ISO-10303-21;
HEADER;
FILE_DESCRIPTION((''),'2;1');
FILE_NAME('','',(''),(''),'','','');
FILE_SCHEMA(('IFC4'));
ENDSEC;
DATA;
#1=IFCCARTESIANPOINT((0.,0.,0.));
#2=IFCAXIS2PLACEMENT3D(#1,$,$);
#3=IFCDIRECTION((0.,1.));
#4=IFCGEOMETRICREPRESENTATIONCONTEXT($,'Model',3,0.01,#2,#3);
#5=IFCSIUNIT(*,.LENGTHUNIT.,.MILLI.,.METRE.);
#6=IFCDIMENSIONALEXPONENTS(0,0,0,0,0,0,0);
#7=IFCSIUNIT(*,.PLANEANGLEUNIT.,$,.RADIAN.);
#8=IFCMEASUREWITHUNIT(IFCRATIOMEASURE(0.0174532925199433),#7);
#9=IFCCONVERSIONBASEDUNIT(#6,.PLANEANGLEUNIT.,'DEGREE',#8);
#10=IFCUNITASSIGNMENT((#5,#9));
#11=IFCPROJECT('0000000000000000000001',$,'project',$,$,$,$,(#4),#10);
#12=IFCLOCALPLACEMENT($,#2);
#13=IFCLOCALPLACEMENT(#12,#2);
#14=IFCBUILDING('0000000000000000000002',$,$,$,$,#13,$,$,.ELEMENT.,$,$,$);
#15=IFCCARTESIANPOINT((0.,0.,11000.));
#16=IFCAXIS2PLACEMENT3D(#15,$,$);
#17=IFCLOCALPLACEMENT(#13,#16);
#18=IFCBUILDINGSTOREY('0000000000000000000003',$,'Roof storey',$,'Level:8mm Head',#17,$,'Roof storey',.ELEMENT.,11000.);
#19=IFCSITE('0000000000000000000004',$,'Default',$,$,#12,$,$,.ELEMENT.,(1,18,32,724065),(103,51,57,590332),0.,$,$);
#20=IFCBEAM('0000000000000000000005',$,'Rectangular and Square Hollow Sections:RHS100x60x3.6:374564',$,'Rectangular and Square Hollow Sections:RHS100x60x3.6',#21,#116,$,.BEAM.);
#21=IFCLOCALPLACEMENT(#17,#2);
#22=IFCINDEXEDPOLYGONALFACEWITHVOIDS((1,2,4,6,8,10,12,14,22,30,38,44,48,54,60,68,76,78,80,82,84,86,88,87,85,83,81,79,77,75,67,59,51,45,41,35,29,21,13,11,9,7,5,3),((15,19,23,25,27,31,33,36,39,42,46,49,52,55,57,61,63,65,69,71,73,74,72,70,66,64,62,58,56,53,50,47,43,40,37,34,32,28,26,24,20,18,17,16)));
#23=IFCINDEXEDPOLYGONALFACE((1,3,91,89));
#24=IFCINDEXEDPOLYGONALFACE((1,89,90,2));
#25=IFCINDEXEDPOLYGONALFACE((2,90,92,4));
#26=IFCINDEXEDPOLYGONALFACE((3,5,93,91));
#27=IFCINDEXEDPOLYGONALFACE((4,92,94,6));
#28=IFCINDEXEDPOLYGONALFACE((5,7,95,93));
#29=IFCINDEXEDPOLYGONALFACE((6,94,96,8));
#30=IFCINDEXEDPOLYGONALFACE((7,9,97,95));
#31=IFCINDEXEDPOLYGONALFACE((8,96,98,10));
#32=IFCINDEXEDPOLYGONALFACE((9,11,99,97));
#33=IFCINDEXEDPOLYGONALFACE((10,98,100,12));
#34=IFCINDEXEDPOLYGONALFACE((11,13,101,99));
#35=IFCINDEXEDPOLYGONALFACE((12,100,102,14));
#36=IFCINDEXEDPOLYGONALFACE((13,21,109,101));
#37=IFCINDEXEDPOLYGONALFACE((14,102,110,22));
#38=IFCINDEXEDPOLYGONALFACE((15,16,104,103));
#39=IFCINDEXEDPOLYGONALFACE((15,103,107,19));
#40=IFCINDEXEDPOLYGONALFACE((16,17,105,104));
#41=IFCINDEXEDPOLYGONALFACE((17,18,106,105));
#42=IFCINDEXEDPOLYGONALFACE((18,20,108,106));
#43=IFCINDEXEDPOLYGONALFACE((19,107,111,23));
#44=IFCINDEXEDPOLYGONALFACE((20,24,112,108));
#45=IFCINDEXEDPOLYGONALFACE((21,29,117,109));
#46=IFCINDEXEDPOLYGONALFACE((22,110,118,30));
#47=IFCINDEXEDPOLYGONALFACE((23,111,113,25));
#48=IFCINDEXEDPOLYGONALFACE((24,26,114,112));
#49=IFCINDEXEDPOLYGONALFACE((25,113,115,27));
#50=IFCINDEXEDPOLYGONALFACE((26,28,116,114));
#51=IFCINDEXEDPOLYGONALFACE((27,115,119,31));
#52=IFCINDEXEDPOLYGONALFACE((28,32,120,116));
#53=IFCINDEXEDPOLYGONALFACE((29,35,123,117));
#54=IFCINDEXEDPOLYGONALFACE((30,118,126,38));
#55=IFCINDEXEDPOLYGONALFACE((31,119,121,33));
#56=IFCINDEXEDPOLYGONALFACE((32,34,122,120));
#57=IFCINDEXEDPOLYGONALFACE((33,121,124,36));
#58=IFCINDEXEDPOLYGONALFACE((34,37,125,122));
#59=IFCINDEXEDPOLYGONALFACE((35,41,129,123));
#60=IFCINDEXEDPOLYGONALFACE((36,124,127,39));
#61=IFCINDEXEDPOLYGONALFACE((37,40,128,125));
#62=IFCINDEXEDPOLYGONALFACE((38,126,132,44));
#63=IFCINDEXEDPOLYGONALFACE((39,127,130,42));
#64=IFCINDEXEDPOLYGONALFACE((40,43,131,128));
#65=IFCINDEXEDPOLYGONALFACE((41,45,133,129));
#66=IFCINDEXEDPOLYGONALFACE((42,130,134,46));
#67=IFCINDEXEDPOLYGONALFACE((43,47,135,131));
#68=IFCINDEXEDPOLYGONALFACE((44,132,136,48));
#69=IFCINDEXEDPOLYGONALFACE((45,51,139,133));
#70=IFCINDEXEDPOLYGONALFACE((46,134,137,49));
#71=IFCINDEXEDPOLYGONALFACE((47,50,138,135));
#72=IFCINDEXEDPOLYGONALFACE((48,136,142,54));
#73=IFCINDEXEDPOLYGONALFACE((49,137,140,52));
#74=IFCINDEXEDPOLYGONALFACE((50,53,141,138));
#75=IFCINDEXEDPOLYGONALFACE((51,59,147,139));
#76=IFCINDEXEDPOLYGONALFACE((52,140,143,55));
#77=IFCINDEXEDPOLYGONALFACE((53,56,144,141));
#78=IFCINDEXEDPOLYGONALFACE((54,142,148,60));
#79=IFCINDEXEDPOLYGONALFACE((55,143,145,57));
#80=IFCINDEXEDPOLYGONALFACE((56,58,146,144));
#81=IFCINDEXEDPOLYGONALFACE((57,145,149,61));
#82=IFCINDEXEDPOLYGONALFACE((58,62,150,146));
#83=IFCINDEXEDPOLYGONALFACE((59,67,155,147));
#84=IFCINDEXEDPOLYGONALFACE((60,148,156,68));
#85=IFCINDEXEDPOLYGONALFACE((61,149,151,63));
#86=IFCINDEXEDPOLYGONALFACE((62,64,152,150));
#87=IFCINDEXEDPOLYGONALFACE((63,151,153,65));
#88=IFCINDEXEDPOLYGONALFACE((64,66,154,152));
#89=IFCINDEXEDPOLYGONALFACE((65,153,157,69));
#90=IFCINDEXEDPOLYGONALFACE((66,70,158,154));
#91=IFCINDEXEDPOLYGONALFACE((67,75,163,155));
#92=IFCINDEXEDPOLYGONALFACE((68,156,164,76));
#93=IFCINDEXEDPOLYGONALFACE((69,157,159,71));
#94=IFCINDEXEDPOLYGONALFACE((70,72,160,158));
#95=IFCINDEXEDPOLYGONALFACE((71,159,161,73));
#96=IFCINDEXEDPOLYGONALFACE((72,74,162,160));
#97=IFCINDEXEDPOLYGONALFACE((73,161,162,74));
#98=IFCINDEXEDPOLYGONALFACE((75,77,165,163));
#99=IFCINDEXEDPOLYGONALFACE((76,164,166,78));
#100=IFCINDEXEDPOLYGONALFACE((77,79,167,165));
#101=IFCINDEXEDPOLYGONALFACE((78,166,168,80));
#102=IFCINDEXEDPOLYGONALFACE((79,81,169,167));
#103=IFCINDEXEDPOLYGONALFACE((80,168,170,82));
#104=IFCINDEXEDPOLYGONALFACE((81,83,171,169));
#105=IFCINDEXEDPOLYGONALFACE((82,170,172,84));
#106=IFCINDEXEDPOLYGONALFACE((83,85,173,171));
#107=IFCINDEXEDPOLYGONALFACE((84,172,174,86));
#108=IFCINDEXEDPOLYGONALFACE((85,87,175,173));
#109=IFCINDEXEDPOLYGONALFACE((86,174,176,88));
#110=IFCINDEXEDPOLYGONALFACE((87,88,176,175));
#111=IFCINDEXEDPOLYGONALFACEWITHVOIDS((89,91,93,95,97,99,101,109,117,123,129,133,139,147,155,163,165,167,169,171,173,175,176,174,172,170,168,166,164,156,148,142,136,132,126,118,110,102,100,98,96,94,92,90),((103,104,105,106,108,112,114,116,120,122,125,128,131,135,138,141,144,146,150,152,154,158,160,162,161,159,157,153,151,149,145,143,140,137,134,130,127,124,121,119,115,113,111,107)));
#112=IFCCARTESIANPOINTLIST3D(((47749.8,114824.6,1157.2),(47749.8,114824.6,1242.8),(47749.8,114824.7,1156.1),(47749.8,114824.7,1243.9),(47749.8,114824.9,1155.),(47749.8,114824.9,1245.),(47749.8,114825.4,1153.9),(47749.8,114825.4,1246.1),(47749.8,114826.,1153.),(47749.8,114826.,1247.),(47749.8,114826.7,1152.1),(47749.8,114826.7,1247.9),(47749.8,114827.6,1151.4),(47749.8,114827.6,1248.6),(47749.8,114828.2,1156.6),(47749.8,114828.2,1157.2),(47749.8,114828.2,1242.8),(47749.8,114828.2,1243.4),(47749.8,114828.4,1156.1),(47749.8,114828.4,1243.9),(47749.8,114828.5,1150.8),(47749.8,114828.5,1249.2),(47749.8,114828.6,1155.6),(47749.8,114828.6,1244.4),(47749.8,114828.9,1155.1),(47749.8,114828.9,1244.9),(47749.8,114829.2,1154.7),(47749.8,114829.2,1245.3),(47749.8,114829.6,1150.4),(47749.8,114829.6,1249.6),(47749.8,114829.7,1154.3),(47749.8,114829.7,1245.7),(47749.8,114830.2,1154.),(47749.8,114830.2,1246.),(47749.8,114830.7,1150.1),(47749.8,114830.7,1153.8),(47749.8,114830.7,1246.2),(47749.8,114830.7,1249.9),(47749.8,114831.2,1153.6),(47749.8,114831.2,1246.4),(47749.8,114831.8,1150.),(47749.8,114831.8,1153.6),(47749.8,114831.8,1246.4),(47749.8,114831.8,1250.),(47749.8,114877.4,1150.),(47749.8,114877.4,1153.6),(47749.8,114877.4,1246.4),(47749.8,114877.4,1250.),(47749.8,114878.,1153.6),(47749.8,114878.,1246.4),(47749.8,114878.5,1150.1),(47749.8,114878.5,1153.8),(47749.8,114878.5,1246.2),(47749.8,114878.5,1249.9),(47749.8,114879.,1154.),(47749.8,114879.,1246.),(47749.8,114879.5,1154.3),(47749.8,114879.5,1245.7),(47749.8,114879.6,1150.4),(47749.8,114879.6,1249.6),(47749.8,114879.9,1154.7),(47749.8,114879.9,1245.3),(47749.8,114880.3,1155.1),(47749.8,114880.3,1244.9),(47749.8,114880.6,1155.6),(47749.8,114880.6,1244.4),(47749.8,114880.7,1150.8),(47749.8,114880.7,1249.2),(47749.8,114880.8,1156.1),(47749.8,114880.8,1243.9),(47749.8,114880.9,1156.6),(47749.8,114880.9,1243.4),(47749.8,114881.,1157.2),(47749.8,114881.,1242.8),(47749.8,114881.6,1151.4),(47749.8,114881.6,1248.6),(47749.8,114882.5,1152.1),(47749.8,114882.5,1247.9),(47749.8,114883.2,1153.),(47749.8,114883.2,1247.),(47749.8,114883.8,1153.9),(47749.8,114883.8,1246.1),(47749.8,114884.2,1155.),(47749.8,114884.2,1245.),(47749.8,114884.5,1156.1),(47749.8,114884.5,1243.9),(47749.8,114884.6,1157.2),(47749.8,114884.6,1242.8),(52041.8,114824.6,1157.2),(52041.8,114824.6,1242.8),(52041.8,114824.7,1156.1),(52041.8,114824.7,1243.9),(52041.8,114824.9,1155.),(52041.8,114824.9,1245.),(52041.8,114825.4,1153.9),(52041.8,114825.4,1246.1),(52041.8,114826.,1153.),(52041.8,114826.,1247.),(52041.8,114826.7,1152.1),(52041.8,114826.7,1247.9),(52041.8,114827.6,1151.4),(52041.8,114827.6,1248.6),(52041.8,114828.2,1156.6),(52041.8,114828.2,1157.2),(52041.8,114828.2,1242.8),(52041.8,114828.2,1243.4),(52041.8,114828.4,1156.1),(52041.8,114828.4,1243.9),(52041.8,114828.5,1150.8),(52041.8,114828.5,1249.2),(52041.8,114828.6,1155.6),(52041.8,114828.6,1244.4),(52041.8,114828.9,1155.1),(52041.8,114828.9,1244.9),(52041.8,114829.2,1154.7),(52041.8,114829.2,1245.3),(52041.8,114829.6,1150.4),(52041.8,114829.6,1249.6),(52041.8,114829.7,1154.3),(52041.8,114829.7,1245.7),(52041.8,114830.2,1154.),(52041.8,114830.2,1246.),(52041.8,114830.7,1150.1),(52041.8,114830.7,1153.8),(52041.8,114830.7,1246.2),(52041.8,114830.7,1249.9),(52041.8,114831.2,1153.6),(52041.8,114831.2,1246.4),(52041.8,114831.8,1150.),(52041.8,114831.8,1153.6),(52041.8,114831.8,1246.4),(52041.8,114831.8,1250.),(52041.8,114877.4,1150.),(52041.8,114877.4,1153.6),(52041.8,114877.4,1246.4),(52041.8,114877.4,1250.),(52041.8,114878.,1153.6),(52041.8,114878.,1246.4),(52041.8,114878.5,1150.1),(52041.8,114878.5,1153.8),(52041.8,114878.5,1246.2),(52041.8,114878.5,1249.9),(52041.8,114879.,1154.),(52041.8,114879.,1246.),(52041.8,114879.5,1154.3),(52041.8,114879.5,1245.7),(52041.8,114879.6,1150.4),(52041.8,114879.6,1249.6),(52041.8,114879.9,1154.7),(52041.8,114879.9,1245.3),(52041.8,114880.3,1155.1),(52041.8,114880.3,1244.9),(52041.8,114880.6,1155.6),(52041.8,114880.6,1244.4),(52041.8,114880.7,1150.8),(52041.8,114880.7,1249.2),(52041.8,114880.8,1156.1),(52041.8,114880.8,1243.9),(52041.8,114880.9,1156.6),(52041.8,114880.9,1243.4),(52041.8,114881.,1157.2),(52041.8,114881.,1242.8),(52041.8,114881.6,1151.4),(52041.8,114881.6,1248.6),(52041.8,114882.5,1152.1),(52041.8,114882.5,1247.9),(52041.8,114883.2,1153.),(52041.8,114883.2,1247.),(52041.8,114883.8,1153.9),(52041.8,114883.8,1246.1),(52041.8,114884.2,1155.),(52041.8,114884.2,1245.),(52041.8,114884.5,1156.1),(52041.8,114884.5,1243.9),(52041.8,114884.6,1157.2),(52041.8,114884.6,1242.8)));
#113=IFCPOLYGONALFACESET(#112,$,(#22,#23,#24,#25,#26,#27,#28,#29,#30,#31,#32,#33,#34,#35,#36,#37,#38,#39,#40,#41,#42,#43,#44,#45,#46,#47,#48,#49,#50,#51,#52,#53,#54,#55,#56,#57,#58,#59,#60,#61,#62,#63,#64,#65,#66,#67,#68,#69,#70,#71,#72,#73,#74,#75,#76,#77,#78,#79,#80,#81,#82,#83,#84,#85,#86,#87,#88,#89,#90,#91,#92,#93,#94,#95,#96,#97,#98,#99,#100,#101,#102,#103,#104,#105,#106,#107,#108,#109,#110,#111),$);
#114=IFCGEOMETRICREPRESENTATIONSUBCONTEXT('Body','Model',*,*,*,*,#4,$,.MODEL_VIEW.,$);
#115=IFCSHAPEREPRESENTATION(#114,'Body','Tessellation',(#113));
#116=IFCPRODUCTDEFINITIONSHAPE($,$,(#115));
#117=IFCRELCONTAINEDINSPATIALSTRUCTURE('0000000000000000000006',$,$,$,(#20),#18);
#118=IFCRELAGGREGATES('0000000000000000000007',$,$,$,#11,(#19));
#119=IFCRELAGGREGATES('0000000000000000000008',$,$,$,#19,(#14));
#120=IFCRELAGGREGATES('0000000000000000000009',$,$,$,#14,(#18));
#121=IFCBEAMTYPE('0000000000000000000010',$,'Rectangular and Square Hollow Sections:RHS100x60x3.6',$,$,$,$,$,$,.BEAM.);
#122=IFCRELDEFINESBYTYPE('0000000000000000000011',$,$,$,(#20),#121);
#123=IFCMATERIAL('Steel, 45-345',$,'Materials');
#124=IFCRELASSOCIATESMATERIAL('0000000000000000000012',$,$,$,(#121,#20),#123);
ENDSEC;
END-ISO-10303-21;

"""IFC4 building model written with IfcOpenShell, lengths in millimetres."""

from ifc_helpers import new_model, entity, si_unit, converted_unit, direction, frame, origin, place, context, subcontext, project, spatial, indexed_curve, outline, extrude, source, transform, mapped, material, type_object, type_shapes, element, save


model = new_model("IFC4")

# Units and contexts
model_context = context("Model", 3, precision=0.01, world=origin(), true_north=direction((0.0, 1.0)))
body_context = subcontext(model_context, "Body", "Model", "MODEL_VIEW")
ifc_project = project(units=[si_unit("LENGTHUNIT", "METRE", prefix="MILLI"), converted_unit("PLANEANGLEUNIT", "DEGREE", entity("IfcRatioMeasure", 0.0174532925199433), si_unit("PLANEANGLEUNIT", "RADIAN"), dimensions=[0, 0, 0, 0, 0, 0, 0])], contexts=[model_context])

# Site, building, storey
site_placement = place(None, origin())
site = spatial("IfcSite", under=ifc_project, at=site_placement, Name="Default", CompositionType="ELEMENT", RefLatitude=(1, 18, 32, 724065), RefLongitude=(103, 51, 57, 590332), RefElevation=0.0)
building_placement = place(site_placement, origin())
building = spatial("IfcBuilding", under=site, at=building_placement, CompositionType="ELEMENT")
storey_placement = place(building_placement, frame((0.0, 0.0, 11000.0)))
storey = spatial("IfcBuildingStorey", under=building, at=storey_placement, Name="Roof storey", ObjectType="Level:8mm Head", LongName="Roof storey", CompositionType="ELEMENT", Elevation=11000.0)

# Shared definitions
ifc_material = material(Name="Steel, 45-345", Category="Materials")

# Beam
beam_type_1 = type_object("IfcBeamType", Name="Rectangular and Square Hollow Sections:RHS100x60x3.6", PredefinedType="BEAM", material=ifc_material)
shared_shape_1 = source(origin(), body_context, "Body", "SweptSolid", [
    extrude(outline(indexed_curve([(-30.0, -42.8), (-29.9, -43.9), (-29.6, -45.0), (-29.2, -46.1), (-28.6, -47.0), (-27.9, -47.9), (-27.0, -48.6), (-26.1, -49.2), (-25.0, -49.6), (-23.9, -49.9), (-22.8, -50.0), (22.8, -50.0), (23.9, -49.9), (25.0, -49.6), (26.1, -49.2), (27.0, -48.6), (27.9, -47.9), (28.6, -47.0), (29.2, -46.1), (29.6, -45.0), (29.9, -43.9), (30.0, -42.8), (30.0, 42.8), (29.9, 43.9), (29.6, 45.0), (29.2, 46.1), (28.6, 47.0), (27.9, 47.9), (27.0, 48.6), (26.1, 49.2), (25.0, 49.6), (23.9, 49.9), (22.8, 50.0), (-22.8, 50.0), (-23.9, 49.9), (-25.0, 49.6), (-26.1, 49.2), (-27.0, 48.6), (-27.9, 47.9), (-28.6, 47.0), (-29.2, 46.1), (-29.6, 45.0), (-29.9, 43.9), (-30.0, 42.8), (-30.0, -42.8)], self_intersect=False), holes=[indexed_curve([(22.8, -46.4), (-22.8, -46.4), (-23.4, -46.4), (-23.9, -46.2), (-24.4, -46.0), (-24.9, -45.7), (-25.3, -45.3), (-25.7, -44.9), (-26.0, -44.4), (-26.2, -43.9), (-26.4, -43.4), (-26.4, -42.8), (-26.4, 42.8), (-26.4, 43.4), (-26.2, 43.9), (-26.0, 44.4), (-25.7, 44.9), (-25.3, 45.3), (-24.9, 45.7), (-24.4, 46.0), (-23.9, 46.2), (-23.4, 46.4), (-22.8, 46.4), (22.8, 46.4), (23.4, 46.4), (23.9, 46.2), (24.4, 46.0), (24.9, 45.7), (25.3, 45.3), (25.7, 44.9), (26.0, 44.4), (26.2, 43.9), (26.4, 43.4), (26.4, 42.8), (26.4, -42.8), (26.4, -43.4), (26.2, -43.9), (26.0, -44.4), (25.7, -44.9), (25.3, -45.3), (24.9, -45.7), (24.4, -46.0), (23.9, -46.2), (23.4, -46.4), (22.8, -46.4)], self_intersect=False)]), frame((-2139.5, 0.0, 0.0), z_axis=(1.0, 0.0, 0.0), x_axis=(0.0, -1.0, 0.0)), (0.0, 0.0, 1.0), 4292.0),
])
type_shapes(beam_type_1, [shared_shape_1])
for number, where, name in (
    (1, (49889.3, 114854.6, 1200.0), "Rectangular and Square Hollow Sections:RHS100x60x3.6:374564"),
):
    element("IfcBeam", number, at=place(storey_placement, frame(where)), inside=storey, type_object=beam_type_1, material=ifc_material, Name=name, ObjectType="Rectangular and Square Hollow Sections:RHS100x60x3.6", PredefinedType="BEAM", context=body_context, shape_type="MappedRepresentation", body=[
        mapped(shared_shape_1, transform((0.0, 0.0, 0.0), scale=1.0)),
    ])

save(model, "model.ifc")
